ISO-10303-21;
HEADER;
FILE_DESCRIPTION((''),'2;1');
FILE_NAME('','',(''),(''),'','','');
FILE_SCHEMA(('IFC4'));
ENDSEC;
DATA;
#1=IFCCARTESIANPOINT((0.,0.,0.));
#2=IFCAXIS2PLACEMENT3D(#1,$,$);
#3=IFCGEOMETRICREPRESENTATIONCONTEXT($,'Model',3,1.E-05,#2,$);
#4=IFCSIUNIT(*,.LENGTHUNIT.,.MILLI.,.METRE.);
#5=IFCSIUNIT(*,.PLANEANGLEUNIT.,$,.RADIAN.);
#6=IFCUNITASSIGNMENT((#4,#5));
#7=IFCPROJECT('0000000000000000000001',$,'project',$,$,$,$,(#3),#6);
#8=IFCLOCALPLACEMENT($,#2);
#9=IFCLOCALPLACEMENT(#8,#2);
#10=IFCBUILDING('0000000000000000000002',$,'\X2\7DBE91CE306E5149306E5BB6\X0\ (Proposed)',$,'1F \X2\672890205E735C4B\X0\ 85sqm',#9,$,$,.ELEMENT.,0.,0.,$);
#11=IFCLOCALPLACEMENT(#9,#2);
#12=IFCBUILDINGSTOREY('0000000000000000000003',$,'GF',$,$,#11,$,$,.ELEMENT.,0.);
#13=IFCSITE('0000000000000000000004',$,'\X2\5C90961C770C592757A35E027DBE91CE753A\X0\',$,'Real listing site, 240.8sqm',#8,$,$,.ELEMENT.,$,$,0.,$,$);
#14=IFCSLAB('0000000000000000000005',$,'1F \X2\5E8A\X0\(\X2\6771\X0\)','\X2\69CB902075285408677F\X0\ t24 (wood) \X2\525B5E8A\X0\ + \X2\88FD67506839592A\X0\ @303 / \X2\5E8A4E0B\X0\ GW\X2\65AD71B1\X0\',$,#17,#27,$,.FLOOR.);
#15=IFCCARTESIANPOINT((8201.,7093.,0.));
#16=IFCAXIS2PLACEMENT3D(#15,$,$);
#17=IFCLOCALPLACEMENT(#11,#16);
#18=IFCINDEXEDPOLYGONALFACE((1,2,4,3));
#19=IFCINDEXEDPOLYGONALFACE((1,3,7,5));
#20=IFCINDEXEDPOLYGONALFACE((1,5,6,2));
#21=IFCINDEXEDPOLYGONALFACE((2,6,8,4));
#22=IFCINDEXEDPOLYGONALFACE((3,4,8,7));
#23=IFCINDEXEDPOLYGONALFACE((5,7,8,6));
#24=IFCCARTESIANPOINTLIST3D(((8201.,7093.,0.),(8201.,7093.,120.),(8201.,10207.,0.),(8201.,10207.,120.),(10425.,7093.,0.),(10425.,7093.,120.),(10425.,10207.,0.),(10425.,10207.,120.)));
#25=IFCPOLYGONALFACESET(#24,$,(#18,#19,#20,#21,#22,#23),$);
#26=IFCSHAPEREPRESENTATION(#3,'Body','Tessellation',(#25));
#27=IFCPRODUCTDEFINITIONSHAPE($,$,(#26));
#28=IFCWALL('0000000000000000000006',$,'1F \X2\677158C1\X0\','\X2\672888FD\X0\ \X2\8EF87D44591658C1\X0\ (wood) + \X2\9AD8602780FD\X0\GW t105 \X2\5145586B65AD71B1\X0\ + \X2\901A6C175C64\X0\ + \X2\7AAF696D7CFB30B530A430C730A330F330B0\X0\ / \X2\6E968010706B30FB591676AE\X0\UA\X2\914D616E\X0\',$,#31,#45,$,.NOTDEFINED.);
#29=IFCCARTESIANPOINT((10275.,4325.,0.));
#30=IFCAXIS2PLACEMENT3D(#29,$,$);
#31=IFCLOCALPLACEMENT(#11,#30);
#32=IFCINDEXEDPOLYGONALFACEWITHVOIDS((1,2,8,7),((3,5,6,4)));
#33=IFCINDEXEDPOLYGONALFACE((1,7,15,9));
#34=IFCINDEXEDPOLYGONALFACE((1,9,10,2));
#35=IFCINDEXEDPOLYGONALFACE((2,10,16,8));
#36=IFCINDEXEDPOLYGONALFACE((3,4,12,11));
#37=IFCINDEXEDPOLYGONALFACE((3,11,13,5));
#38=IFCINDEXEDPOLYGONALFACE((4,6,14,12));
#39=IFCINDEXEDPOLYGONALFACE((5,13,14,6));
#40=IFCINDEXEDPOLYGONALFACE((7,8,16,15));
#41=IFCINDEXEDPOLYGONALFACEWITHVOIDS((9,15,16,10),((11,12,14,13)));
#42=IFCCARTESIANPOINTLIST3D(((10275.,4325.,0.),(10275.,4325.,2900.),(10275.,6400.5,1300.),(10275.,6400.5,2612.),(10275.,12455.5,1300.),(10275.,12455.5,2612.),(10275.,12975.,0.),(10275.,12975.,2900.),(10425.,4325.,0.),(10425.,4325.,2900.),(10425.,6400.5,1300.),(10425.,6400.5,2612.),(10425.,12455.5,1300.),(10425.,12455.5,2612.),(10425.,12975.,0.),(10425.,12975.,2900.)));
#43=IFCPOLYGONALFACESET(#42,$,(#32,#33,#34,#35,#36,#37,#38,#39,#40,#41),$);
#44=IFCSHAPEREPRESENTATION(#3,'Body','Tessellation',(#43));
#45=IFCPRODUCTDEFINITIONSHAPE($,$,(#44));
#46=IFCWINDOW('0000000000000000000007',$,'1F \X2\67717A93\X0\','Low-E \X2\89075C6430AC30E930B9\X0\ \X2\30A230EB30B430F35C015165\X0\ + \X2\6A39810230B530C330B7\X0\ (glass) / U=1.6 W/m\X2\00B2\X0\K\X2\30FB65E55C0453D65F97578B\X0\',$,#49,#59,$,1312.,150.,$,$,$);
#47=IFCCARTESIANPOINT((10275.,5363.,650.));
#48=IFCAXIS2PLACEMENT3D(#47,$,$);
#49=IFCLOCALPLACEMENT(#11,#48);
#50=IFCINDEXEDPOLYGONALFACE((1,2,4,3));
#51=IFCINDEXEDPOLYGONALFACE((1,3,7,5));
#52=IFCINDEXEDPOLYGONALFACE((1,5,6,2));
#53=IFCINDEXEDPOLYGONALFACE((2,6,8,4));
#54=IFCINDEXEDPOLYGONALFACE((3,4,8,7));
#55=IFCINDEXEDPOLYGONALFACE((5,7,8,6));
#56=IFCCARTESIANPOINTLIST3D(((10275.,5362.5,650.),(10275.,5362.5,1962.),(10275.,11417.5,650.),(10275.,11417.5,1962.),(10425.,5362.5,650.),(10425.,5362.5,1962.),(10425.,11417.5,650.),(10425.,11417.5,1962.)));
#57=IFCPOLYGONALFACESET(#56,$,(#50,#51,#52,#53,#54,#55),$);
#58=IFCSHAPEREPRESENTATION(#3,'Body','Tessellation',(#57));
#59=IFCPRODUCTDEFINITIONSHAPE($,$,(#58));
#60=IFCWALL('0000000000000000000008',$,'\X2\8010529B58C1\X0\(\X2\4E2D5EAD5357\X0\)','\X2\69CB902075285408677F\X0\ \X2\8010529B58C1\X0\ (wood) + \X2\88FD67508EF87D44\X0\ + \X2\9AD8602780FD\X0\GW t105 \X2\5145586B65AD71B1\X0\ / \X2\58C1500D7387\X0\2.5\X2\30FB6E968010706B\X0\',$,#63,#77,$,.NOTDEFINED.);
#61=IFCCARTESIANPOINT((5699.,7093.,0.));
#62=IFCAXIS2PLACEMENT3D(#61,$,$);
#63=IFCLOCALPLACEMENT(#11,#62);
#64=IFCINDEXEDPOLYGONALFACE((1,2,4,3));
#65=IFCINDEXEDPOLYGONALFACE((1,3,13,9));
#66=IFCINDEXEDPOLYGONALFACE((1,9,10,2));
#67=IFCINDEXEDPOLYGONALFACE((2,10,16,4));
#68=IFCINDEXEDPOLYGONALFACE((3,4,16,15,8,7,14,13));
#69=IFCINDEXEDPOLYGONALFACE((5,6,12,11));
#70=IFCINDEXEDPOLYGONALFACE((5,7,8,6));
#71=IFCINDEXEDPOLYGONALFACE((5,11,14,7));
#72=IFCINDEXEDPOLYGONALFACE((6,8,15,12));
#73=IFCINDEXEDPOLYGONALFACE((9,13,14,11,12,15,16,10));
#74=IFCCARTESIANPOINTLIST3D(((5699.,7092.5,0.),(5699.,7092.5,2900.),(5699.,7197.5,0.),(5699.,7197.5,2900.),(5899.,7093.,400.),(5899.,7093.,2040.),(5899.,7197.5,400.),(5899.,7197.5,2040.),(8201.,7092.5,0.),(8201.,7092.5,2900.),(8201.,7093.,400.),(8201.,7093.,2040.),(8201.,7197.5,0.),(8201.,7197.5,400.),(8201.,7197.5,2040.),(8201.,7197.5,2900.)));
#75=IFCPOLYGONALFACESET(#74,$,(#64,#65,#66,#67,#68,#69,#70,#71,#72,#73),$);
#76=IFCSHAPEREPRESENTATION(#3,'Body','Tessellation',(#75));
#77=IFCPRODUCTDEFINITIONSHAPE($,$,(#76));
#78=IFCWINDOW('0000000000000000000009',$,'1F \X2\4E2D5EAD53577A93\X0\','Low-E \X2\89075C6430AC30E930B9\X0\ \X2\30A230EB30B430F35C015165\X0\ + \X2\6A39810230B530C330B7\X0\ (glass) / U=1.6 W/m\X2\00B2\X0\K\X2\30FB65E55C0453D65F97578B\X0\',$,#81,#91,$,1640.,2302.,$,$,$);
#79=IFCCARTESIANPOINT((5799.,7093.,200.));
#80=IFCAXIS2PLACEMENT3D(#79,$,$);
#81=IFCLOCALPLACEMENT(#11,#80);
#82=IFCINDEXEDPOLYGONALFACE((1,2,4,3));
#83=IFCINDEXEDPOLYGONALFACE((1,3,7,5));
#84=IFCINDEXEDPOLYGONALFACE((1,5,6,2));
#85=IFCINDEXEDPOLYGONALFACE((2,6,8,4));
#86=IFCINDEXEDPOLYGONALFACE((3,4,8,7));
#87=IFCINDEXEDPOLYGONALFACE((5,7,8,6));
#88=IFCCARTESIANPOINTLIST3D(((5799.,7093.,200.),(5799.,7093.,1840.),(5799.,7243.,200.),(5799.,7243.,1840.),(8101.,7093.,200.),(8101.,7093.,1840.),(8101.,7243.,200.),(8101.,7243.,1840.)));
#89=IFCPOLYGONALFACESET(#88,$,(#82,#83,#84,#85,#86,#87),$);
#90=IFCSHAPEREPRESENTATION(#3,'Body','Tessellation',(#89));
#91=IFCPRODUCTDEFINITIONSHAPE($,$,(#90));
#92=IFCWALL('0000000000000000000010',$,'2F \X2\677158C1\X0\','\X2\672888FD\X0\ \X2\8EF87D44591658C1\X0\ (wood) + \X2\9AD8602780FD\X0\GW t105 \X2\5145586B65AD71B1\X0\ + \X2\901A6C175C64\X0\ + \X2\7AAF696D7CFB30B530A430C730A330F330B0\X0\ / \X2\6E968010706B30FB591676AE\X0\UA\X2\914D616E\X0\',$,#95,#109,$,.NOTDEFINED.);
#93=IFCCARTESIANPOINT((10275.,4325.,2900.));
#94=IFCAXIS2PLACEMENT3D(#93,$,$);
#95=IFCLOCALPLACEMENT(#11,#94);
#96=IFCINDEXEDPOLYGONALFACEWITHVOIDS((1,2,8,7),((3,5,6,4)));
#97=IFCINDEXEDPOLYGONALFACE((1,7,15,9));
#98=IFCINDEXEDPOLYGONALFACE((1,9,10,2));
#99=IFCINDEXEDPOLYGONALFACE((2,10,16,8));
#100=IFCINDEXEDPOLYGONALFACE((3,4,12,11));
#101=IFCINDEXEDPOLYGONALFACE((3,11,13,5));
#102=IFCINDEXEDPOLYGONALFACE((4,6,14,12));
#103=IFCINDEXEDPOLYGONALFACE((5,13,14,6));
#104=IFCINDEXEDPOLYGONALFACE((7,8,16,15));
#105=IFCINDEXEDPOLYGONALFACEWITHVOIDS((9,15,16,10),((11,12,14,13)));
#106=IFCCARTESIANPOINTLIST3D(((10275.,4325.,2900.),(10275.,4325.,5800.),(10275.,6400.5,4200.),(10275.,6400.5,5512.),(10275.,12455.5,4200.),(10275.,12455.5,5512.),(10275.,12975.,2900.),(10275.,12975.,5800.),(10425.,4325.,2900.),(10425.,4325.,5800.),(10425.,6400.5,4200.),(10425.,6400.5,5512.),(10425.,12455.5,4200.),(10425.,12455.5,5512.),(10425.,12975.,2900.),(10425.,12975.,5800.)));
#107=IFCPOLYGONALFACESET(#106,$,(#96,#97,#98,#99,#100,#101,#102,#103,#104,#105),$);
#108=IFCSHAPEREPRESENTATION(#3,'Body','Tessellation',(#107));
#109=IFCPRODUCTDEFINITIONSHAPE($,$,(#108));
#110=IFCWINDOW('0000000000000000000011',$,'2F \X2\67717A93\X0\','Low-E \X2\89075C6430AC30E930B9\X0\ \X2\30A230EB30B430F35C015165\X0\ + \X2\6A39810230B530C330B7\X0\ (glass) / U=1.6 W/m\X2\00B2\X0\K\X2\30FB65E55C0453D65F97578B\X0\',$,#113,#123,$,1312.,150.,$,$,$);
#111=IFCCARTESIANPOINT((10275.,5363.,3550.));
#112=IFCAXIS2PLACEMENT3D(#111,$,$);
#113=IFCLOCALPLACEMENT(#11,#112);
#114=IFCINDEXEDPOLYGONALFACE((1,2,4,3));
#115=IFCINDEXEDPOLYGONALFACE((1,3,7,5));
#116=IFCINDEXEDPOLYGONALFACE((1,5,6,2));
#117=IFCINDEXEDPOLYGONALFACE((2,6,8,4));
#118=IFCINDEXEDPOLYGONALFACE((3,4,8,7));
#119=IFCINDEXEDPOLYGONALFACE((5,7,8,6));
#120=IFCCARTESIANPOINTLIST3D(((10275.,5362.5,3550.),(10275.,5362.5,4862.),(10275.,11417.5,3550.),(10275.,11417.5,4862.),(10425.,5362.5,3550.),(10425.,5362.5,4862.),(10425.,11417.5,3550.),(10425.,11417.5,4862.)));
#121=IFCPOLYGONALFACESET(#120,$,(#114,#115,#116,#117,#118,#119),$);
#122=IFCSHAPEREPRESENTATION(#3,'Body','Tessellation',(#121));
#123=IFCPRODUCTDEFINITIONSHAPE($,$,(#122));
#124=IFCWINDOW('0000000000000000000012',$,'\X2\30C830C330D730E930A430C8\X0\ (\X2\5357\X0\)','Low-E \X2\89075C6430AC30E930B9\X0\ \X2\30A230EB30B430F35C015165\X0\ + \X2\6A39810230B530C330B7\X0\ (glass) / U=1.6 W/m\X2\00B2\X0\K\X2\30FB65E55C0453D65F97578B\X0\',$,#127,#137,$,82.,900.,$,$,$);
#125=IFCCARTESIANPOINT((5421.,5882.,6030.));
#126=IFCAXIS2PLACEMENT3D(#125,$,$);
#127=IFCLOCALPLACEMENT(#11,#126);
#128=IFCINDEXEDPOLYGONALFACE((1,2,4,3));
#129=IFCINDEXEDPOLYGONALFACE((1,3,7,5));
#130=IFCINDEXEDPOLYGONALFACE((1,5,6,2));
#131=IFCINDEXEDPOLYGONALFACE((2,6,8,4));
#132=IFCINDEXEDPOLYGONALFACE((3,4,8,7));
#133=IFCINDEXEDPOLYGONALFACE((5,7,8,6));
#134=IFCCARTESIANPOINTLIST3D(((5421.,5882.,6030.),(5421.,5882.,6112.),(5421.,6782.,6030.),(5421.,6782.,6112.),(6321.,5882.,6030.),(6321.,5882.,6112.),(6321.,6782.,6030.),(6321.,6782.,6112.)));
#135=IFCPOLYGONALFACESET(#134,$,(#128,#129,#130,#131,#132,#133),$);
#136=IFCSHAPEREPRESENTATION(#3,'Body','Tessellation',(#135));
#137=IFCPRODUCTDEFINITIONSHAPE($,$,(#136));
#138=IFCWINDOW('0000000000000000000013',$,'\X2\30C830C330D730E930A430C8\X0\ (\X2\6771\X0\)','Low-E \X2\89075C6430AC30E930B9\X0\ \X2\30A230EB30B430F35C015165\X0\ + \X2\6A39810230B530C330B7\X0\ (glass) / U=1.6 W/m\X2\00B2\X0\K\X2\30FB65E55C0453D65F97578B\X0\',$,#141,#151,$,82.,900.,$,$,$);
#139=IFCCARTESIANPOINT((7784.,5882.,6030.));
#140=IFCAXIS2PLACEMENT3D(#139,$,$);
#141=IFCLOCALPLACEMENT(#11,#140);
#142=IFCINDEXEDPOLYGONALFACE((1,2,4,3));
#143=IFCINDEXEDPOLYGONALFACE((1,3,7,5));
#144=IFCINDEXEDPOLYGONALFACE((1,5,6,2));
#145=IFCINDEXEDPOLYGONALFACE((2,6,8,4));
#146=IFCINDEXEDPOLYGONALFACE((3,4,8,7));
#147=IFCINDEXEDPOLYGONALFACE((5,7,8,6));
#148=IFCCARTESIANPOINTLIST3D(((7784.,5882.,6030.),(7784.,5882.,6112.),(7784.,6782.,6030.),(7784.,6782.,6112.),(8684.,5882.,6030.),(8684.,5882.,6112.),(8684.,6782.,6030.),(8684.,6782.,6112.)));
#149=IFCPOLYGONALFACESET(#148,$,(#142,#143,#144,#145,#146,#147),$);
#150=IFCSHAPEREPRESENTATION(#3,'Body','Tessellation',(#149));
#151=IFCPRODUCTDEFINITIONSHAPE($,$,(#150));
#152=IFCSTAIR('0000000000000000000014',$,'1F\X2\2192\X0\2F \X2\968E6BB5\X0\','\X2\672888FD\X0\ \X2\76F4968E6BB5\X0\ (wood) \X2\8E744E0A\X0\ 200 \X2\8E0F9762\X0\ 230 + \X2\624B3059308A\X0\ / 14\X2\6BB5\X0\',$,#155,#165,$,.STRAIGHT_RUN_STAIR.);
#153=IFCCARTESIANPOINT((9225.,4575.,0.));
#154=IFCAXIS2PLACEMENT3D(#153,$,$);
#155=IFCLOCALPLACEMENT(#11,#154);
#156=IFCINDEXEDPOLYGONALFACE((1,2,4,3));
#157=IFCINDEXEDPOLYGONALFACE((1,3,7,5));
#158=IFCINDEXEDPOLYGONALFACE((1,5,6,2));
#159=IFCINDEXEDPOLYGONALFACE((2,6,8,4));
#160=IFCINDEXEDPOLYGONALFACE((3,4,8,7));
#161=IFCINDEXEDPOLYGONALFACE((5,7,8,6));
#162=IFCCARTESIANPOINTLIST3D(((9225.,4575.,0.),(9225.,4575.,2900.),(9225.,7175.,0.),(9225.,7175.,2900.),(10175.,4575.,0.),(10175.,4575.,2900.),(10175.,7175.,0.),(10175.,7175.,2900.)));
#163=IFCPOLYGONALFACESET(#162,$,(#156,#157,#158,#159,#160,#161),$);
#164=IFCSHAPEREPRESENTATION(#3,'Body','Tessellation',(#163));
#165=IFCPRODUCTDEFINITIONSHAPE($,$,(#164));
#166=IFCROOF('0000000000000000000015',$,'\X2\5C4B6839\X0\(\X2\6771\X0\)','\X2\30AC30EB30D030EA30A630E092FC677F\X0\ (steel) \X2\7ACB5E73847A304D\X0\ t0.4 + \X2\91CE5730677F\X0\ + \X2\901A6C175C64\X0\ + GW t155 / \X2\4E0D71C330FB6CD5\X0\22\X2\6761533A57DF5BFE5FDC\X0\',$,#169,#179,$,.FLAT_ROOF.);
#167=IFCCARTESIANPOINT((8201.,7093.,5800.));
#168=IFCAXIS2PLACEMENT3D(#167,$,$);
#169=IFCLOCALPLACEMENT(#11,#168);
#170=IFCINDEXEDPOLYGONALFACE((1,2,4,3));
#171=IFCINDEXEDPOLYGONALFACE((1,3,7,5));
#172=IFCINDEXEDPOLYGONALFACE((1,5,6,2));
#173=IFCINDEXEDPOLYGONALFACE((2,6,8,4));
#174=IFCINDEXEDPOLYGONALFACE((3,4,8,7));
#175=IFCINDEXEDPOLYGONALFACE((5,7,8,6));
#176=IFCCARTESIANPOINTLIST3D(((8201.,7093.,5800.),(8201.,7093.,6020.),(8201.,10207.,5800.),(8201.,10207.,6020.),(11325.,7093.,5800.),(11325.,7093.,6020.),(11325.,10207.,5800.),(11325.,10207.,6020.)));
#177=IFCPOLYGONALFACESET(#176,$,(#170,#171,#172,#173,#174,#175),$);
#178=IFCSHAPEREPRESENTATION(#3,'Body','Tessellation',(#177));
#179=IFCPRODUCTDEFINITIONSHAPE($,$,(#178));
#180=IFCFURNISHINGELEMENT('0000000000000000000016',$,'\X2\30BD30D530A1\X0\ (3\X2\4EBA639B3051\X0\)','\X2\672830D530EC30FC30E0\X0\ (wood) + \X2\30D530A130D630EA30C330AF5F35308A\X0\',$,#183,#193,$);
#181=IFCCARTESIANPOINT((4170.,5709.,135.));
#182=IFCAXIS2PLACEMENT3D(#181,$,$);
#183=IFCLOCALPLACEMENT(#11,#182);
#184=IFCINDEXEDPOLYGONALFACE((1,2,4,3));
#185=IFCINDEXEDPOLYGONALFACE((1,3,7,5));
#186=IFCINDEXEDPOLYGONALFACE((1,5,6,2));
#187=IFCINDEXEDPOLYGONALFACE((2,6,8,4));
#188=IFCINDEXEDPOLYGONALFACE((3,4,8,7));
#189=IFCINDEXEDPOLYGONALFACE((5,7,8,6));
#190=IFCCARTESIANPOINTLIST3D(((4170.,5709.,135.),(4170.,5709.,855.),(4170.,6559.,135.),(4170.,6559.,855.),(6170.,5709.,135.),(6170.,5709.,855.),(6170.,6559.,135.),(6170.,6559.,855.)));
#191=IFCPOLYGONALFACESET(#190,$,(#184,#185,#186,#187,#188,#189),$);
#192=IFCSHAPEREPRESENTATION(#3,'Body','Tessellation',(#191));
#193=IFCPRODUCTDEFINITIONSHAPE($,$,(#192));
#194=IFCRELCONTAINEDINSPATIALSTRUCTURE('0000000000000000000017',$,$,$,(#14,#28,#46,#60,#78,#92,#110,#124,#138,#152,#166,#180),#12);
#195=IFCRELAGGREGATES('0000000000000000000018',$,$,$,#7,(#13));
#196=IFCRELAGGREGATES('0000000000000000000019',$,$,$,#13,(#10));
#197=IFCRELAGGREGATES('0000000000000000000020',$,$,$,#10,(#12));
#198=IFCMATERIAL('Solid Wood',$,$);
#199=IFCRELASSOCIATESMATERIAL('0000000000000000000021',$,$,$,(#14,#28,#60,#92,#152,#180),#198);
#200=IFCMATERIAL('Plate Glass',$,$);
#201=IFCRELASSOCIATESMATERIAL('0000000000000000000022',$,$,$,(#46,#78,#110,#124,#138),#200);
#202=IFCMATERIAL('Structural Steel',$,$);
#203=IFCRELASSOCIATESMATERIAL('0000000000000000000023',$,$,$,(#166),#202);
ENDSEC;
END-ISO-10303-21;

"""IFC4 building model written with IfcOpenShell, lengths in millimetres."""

from ifc_helpers import new_model, si_unit, frame, frame_2d, origin, place, context, project, spatial, rectangle, extrude, material, element, fill, save


model = new_model("IFC4")

# Units and contexts
model_context = context("Model", 3, precision=1e-05, world=origin())
ifc_project = project(units=[si_unit("LENGTHUNIT", "METRE", prefix="MILLI"), si_unit("PLANEANGLEUNIT", "RADIAN")], contexts=[model_context])

# Site, building, storey
site_placement = place(None, origin())
site = spatial("IfcSite", under=ifc_project, at=site_placement, Name="岐阜県大垣市綾野町", ObjectType="Real listing site, 240.8sqm", CompositionType="ELEMENT", RefElevation=0.0)
building_placement = place(site_placement, origin())
building = spatial("IfcBuilding", under=site, at=building_placement, Name="綾野の光の家 (Proposed)", ObjectType="1F 木造平屋 85sqm", CompositionType="ELEMENT", ElevationOfRefHeight=0.0, ElevationOfTerrain=0.0)
storey_placement = place(building_placement, origin())
storey = spatial("IfcBuildingStorey", under=building, at=storey_placement, Name="GF", CompositionType="ELEMENT", Elevation=0.0)

# Slab
ifc_material_1 = material(Name="Solid Wood")
slab_placement = place(storey_placement, frame((8201.0, 7093.0, 0.0)))
element("IfcSlab", 1, at=slab_placement, inside=storey, material=ifc_material_1, Name="1F 床(東)", Description="構造用合板 t24 (wood) 剛床 + 製材根太 @303 / 床下 GW断熱", PredefinedType="FLOOR", context=model_context, shape_type="SweptSolid", body=[
    extrude(rectangle(XDim=2224.0, YDim=3114.0, at=frame_2d((1112.0, 1557.0))), frame((8201.0, 7093.0, 0.0)), (0.0, 0.0, 1.0), 120.0),
])

# Walls, openings, windows
wall_1_placement = place(storey_placement, frame((10275.0, 4325.0, 0.0)))
wall_1 = element("IfcWall", 2, at=wall_1_placement, inside=storey, material=ifc_material_1, Name="1F 東壁", Description="木製 軸組外壁 (wood) + 高性能GW t105 充填断熱 + 通気層 + 窯業系サイディング / 準耐火・外皮UA配慮", PredefinedType="NOTDEFINED", context=model_context, shape_type="SweptSolid", body=[
    extrude(rectangle(XDim=150.0, YDim=8650.0, at=frame_2d((75.0, 4325.0))), frame((10275.0, 4325.0, 0.0)), (0.0, 0.0, 1.0), 2900.0),
])
opening_1_placement = place(storey_placement, frame((10275.0, 5363.0, 650.0)))
opening_1 = element("IfcOpeningElement", 3, at=opening_1_placement, cuts=wall_1, PredefinedType="NOTDEFINED", context=model_context, shape_type="SweptSolid", body=[
    extrude(rectangle(XDim=150.0, YDim=6055.0, at=frame_2d((75.0, 3027.0))), frame((10275.0, 5363.0, 650.0)), (0.0, 0.0, 1.0), 1312.0),
])
ifc_material_2 = material(Name="Plate Glass")
window_1_placement = place(storey_placement, frame((10275.0, 5363.0, 650.0)))
window_1 = element("IfcWindow", 4, at=window_1_placement, inside=storey, material=ifc_material_2, Name="1F 東窓", Description="Low-E 複層ガラス アルゴン封入 + 樹脂サッシ (glass) / U=1.6 W/m²K・日射取得型", OverallHeight=1312.0, OverallWidth=150.0, context=model_context, shape_type="SweptSolid", body=[
    extrude(rectangle(XDim=150.0, YDim=6055.0, at=frame_2d((75.0, 3027.0))), frame((10275.0, 5363.0, 650.0)), (0.0, 0.0, 1.0), 1312.0),
])
fill(opening_1, window_1)
wall_2_placement = place(storey_placement, frame((5699.0, 7093.0, 0.0)))
wall_2 = element("IfcWall", 5, at=wall_2_placement, inside=storey, material=ifc_material_1, Name="耐力壁(中庭南)", Description="構造用合板 耐力壁 (wood) + 製材軸組 + 高性能GW t105 充填断熱 / 壁倍率2.5・準耐火", PredefinedType="NOTDEFINED", context=model_context, shape_type="SweptSolid", body=[
    extrude(rectangle(XDim=2502.0, YDim=105.0, at=frame_2d((1251.0, 52.0))), frame((5699.0, 7093.0, 0.0)), (0.0, 0.0, 1.0), 2900.0),
])
opening_2_placement = place(storey_placement, frame((5799.0, 7093.0, 200.0)))
opening_2 = element("IfcOpeningElement", 6, at=opening_2_placement, cuts=wall_2, PredefinedType="NOTDEFINED", context=model_context, shape_type="SweptSolid", body=[
    extrude(rectangle(XDim=2302.0, YDim=150.0, at=frame_2d((1151.0, 75.0))), frame((5799.0, 7093.0, 200.0)), (0.0, 0.0, 1.0), 1640.0),
])
window_2_placement = place(storey_placement, frame((5799.0, 7093.0, 200.0)))
window_2 = element("IfcWindow", 7, at=window_2_placement, inside=storey, material=ifc_material_2, Name="1F 中庭南窓", Description="Low-E 複層ガラス アルゴン封入 + 樹脂サッシ (glass) / U=1.6 W/m²K・日射取得型", OverallHeight=1640.0, OverallWidth=2302.0, context=model_context, shape_type="SweptSolid", body=[
    extrude(rectangle(XDim=2302.0, YDim=150.0, at=frame_2d((1151.0, 75.0))), frame((5799.0, 7093.0, 200.0)), (0.0, 0.0, 1.0), 1640.0),
])
fill(opening_2, window_2)

# Wall, opening, window
wall_3_placement = place(storey_placement, frame((10275.0, 4325.0, 2900.0)))
wall_3 = element("IfcWall", 8, at=wall_3_placement, inside=storey, material=ifc_material_1, Name="2F 東壁", Description="木製 軸組外壁 (wood) + 高性能GW t105 充填断熱 + 通気層 + 窯業系サイディング / 準耐火・外皮UA配慮", PredefinedType="NOTDEFINED", context=model_context, shape_type="SweptSolid", body=[
    extrude(rectangle(XDim=150.0, YDim=8650.0, at=frame_2d((75.0, 4325.0))), frame((10275.0, 4325.0, 2900.0)), (0.0, 0.0, 1.0), 2900.0),
])
opening_3_placement = place(storey_placement, frame((10275.0, 5363.0, 3550.0)))
opening_3 = element("IfcOpeningElement", 9, at=opening_3_placement, cuts=wall_3, PredefinedType="NOTDEFINED", context=model_context, shape_type="SweptSolid", body=[
    extrude(rectangle(XDim=150.0, YDim=6055.0, at=frame_2d((75.0, 3027.0))), frame((10275.0, 5363.0, 3550.0)), (0.0, 0.0, 1.0), 1312.0),
])
window_3_placement = place(storey_placement, frame((10275.0, 5363.0, 3550.0)))
window_3 = element("IfcWindow", 10, at=window_3_placement, inside=storey, material=ifc_material_2, Name="2F 東窓", Description="Low-E 複層ガラス アルゴン封入 + 樹脂サッシ (glass) / U=1.6 W/m²K・日射取得型", OverallHeight=1312.0, OverallWidth=150.0, context=model_context, shape_type="SweptSolid", body=[
    extrude(rectangle(XDim=150.0, YDim=6055.0, at=frame_2d((75.0, 3027.0))), frame((10275.0, 5363.0, 3550.0)), (0.0, 0.0, 1.0), 1312.0),
])
fill(opening_3, window_3)

# Windows
window_4_placement = place(storey_placement, frame((5421.0, 5882.0, 6030.0)))
element("IfcWindow", 11, at=window_4_placement, inside=storey, material=ifc_material_2, Name="トップライト (南)", Description="Low-E 複層ガラス アルゴン封入 + 樹脂サッシ (glass) / U=1.6 W/m²K・日射取得型", OverallHeight=82.0, OverallWidth=900.0, context=model_context, shape_type="SweptSolid", body=[
    extrude(rectangle(XDim=900.0, YDim=900.0, at=frame_2d((450.0, 450.0))), frame((5421.0, 5882.0, 6030.0)), (0.0, 0.0, 1.0), 82.0),
])
window_5_placement = place(storey_placement, frame((7784.0, 5882.0, 6030.0)))
element("IfcWindow", 12, at=window_5_placement, inside=storey, material=ifc_material_2, Name="トップライト (東)", Description="Low-E 複層ガラス アルゴン封入 + 樹脂サッシ (glass) / U=1.6 W/m²K・日射取得型", OverallHeight=82.0, OverallWidth=900.0, context=model_context, shape_type="SweptSolid", body=[
    extrude(rectangle(XDim=900.0, YDim=900.0, at=frame_2d((450.0, 450.0))), frame((7784.0, 5882.0, 6030.0)), (0.0, 0.0, 1.0), 82.0),
])

# Stair
stair_placement = place(storey_placement, frame((9225.0, 4575.0, 0.0)))
element("IfcStair", 13, at=stair_placement, inside=storey, material=ifc_material_1, Name="1F→2F 階段", Description="木製 直階段 (wood) 蹴上 200 踏面 230 + 手すり / 14段", PredefinedType="STRAIGHT_RUN_STAIR", context=model_context, shape_type="SweptSolid", body=[
    extrude(rectangle(XDim=950.0, YDim=2600.0, at=frame_2d((475.0, 1300.0))), frame((9225.0, 4575.0, 0.0)), (0.0, 0.0, 1.0), 2900.0),
])

# Roof
ifc_material_3 = material(Name="Structural Steel")
roof_placement = place(storey_placement, frame((8201.0, 7093.0, 5800.0)))
element("IfcRoof", 14, at=roof_placement, inside=storey, material=ifc_material_3, Name="屋根(東)", Description="ガルバリウム鋼板 (steel) 立平葺き t0.4 + 野地板 + 通気層 + GW t155 / 不燃・法22条区域対応", PredefinedType="FLAT_ROOF", context=model_context, shape_type="SweptSolid", body=[
    extrude(rectangle(XDim=3124.0, YDim=3114.0, at=frame_2d((1562.0, 1557.0))), frame((8201.0, 7093.0, 5800.0)), (0.0, 0.0, 1.0), 220.0),
])

# Furnishing element
furnishing_1_placement = place(storey_placement, frame((4170.0, 5709.0, 135.0)))
element("IfcFurnishingElement", 15, at=furnishing_1_placement, inside=storey, material=ifc_material_1, Name="ソファ (3人掛け)", Description="木フレーム (wood) + ファブリック張り", context=model_context, shape_type="SweptSolid", body=[
    extrude(rectangle(XDim=2000.0, YDim=850.0, at=frame_2d((1000.0, 425.0))), frame((4170.0, 5709.0, 135.0)), (0.0, 0.0, 1.0), 720.0),
])

save(model, "model.ifc")
